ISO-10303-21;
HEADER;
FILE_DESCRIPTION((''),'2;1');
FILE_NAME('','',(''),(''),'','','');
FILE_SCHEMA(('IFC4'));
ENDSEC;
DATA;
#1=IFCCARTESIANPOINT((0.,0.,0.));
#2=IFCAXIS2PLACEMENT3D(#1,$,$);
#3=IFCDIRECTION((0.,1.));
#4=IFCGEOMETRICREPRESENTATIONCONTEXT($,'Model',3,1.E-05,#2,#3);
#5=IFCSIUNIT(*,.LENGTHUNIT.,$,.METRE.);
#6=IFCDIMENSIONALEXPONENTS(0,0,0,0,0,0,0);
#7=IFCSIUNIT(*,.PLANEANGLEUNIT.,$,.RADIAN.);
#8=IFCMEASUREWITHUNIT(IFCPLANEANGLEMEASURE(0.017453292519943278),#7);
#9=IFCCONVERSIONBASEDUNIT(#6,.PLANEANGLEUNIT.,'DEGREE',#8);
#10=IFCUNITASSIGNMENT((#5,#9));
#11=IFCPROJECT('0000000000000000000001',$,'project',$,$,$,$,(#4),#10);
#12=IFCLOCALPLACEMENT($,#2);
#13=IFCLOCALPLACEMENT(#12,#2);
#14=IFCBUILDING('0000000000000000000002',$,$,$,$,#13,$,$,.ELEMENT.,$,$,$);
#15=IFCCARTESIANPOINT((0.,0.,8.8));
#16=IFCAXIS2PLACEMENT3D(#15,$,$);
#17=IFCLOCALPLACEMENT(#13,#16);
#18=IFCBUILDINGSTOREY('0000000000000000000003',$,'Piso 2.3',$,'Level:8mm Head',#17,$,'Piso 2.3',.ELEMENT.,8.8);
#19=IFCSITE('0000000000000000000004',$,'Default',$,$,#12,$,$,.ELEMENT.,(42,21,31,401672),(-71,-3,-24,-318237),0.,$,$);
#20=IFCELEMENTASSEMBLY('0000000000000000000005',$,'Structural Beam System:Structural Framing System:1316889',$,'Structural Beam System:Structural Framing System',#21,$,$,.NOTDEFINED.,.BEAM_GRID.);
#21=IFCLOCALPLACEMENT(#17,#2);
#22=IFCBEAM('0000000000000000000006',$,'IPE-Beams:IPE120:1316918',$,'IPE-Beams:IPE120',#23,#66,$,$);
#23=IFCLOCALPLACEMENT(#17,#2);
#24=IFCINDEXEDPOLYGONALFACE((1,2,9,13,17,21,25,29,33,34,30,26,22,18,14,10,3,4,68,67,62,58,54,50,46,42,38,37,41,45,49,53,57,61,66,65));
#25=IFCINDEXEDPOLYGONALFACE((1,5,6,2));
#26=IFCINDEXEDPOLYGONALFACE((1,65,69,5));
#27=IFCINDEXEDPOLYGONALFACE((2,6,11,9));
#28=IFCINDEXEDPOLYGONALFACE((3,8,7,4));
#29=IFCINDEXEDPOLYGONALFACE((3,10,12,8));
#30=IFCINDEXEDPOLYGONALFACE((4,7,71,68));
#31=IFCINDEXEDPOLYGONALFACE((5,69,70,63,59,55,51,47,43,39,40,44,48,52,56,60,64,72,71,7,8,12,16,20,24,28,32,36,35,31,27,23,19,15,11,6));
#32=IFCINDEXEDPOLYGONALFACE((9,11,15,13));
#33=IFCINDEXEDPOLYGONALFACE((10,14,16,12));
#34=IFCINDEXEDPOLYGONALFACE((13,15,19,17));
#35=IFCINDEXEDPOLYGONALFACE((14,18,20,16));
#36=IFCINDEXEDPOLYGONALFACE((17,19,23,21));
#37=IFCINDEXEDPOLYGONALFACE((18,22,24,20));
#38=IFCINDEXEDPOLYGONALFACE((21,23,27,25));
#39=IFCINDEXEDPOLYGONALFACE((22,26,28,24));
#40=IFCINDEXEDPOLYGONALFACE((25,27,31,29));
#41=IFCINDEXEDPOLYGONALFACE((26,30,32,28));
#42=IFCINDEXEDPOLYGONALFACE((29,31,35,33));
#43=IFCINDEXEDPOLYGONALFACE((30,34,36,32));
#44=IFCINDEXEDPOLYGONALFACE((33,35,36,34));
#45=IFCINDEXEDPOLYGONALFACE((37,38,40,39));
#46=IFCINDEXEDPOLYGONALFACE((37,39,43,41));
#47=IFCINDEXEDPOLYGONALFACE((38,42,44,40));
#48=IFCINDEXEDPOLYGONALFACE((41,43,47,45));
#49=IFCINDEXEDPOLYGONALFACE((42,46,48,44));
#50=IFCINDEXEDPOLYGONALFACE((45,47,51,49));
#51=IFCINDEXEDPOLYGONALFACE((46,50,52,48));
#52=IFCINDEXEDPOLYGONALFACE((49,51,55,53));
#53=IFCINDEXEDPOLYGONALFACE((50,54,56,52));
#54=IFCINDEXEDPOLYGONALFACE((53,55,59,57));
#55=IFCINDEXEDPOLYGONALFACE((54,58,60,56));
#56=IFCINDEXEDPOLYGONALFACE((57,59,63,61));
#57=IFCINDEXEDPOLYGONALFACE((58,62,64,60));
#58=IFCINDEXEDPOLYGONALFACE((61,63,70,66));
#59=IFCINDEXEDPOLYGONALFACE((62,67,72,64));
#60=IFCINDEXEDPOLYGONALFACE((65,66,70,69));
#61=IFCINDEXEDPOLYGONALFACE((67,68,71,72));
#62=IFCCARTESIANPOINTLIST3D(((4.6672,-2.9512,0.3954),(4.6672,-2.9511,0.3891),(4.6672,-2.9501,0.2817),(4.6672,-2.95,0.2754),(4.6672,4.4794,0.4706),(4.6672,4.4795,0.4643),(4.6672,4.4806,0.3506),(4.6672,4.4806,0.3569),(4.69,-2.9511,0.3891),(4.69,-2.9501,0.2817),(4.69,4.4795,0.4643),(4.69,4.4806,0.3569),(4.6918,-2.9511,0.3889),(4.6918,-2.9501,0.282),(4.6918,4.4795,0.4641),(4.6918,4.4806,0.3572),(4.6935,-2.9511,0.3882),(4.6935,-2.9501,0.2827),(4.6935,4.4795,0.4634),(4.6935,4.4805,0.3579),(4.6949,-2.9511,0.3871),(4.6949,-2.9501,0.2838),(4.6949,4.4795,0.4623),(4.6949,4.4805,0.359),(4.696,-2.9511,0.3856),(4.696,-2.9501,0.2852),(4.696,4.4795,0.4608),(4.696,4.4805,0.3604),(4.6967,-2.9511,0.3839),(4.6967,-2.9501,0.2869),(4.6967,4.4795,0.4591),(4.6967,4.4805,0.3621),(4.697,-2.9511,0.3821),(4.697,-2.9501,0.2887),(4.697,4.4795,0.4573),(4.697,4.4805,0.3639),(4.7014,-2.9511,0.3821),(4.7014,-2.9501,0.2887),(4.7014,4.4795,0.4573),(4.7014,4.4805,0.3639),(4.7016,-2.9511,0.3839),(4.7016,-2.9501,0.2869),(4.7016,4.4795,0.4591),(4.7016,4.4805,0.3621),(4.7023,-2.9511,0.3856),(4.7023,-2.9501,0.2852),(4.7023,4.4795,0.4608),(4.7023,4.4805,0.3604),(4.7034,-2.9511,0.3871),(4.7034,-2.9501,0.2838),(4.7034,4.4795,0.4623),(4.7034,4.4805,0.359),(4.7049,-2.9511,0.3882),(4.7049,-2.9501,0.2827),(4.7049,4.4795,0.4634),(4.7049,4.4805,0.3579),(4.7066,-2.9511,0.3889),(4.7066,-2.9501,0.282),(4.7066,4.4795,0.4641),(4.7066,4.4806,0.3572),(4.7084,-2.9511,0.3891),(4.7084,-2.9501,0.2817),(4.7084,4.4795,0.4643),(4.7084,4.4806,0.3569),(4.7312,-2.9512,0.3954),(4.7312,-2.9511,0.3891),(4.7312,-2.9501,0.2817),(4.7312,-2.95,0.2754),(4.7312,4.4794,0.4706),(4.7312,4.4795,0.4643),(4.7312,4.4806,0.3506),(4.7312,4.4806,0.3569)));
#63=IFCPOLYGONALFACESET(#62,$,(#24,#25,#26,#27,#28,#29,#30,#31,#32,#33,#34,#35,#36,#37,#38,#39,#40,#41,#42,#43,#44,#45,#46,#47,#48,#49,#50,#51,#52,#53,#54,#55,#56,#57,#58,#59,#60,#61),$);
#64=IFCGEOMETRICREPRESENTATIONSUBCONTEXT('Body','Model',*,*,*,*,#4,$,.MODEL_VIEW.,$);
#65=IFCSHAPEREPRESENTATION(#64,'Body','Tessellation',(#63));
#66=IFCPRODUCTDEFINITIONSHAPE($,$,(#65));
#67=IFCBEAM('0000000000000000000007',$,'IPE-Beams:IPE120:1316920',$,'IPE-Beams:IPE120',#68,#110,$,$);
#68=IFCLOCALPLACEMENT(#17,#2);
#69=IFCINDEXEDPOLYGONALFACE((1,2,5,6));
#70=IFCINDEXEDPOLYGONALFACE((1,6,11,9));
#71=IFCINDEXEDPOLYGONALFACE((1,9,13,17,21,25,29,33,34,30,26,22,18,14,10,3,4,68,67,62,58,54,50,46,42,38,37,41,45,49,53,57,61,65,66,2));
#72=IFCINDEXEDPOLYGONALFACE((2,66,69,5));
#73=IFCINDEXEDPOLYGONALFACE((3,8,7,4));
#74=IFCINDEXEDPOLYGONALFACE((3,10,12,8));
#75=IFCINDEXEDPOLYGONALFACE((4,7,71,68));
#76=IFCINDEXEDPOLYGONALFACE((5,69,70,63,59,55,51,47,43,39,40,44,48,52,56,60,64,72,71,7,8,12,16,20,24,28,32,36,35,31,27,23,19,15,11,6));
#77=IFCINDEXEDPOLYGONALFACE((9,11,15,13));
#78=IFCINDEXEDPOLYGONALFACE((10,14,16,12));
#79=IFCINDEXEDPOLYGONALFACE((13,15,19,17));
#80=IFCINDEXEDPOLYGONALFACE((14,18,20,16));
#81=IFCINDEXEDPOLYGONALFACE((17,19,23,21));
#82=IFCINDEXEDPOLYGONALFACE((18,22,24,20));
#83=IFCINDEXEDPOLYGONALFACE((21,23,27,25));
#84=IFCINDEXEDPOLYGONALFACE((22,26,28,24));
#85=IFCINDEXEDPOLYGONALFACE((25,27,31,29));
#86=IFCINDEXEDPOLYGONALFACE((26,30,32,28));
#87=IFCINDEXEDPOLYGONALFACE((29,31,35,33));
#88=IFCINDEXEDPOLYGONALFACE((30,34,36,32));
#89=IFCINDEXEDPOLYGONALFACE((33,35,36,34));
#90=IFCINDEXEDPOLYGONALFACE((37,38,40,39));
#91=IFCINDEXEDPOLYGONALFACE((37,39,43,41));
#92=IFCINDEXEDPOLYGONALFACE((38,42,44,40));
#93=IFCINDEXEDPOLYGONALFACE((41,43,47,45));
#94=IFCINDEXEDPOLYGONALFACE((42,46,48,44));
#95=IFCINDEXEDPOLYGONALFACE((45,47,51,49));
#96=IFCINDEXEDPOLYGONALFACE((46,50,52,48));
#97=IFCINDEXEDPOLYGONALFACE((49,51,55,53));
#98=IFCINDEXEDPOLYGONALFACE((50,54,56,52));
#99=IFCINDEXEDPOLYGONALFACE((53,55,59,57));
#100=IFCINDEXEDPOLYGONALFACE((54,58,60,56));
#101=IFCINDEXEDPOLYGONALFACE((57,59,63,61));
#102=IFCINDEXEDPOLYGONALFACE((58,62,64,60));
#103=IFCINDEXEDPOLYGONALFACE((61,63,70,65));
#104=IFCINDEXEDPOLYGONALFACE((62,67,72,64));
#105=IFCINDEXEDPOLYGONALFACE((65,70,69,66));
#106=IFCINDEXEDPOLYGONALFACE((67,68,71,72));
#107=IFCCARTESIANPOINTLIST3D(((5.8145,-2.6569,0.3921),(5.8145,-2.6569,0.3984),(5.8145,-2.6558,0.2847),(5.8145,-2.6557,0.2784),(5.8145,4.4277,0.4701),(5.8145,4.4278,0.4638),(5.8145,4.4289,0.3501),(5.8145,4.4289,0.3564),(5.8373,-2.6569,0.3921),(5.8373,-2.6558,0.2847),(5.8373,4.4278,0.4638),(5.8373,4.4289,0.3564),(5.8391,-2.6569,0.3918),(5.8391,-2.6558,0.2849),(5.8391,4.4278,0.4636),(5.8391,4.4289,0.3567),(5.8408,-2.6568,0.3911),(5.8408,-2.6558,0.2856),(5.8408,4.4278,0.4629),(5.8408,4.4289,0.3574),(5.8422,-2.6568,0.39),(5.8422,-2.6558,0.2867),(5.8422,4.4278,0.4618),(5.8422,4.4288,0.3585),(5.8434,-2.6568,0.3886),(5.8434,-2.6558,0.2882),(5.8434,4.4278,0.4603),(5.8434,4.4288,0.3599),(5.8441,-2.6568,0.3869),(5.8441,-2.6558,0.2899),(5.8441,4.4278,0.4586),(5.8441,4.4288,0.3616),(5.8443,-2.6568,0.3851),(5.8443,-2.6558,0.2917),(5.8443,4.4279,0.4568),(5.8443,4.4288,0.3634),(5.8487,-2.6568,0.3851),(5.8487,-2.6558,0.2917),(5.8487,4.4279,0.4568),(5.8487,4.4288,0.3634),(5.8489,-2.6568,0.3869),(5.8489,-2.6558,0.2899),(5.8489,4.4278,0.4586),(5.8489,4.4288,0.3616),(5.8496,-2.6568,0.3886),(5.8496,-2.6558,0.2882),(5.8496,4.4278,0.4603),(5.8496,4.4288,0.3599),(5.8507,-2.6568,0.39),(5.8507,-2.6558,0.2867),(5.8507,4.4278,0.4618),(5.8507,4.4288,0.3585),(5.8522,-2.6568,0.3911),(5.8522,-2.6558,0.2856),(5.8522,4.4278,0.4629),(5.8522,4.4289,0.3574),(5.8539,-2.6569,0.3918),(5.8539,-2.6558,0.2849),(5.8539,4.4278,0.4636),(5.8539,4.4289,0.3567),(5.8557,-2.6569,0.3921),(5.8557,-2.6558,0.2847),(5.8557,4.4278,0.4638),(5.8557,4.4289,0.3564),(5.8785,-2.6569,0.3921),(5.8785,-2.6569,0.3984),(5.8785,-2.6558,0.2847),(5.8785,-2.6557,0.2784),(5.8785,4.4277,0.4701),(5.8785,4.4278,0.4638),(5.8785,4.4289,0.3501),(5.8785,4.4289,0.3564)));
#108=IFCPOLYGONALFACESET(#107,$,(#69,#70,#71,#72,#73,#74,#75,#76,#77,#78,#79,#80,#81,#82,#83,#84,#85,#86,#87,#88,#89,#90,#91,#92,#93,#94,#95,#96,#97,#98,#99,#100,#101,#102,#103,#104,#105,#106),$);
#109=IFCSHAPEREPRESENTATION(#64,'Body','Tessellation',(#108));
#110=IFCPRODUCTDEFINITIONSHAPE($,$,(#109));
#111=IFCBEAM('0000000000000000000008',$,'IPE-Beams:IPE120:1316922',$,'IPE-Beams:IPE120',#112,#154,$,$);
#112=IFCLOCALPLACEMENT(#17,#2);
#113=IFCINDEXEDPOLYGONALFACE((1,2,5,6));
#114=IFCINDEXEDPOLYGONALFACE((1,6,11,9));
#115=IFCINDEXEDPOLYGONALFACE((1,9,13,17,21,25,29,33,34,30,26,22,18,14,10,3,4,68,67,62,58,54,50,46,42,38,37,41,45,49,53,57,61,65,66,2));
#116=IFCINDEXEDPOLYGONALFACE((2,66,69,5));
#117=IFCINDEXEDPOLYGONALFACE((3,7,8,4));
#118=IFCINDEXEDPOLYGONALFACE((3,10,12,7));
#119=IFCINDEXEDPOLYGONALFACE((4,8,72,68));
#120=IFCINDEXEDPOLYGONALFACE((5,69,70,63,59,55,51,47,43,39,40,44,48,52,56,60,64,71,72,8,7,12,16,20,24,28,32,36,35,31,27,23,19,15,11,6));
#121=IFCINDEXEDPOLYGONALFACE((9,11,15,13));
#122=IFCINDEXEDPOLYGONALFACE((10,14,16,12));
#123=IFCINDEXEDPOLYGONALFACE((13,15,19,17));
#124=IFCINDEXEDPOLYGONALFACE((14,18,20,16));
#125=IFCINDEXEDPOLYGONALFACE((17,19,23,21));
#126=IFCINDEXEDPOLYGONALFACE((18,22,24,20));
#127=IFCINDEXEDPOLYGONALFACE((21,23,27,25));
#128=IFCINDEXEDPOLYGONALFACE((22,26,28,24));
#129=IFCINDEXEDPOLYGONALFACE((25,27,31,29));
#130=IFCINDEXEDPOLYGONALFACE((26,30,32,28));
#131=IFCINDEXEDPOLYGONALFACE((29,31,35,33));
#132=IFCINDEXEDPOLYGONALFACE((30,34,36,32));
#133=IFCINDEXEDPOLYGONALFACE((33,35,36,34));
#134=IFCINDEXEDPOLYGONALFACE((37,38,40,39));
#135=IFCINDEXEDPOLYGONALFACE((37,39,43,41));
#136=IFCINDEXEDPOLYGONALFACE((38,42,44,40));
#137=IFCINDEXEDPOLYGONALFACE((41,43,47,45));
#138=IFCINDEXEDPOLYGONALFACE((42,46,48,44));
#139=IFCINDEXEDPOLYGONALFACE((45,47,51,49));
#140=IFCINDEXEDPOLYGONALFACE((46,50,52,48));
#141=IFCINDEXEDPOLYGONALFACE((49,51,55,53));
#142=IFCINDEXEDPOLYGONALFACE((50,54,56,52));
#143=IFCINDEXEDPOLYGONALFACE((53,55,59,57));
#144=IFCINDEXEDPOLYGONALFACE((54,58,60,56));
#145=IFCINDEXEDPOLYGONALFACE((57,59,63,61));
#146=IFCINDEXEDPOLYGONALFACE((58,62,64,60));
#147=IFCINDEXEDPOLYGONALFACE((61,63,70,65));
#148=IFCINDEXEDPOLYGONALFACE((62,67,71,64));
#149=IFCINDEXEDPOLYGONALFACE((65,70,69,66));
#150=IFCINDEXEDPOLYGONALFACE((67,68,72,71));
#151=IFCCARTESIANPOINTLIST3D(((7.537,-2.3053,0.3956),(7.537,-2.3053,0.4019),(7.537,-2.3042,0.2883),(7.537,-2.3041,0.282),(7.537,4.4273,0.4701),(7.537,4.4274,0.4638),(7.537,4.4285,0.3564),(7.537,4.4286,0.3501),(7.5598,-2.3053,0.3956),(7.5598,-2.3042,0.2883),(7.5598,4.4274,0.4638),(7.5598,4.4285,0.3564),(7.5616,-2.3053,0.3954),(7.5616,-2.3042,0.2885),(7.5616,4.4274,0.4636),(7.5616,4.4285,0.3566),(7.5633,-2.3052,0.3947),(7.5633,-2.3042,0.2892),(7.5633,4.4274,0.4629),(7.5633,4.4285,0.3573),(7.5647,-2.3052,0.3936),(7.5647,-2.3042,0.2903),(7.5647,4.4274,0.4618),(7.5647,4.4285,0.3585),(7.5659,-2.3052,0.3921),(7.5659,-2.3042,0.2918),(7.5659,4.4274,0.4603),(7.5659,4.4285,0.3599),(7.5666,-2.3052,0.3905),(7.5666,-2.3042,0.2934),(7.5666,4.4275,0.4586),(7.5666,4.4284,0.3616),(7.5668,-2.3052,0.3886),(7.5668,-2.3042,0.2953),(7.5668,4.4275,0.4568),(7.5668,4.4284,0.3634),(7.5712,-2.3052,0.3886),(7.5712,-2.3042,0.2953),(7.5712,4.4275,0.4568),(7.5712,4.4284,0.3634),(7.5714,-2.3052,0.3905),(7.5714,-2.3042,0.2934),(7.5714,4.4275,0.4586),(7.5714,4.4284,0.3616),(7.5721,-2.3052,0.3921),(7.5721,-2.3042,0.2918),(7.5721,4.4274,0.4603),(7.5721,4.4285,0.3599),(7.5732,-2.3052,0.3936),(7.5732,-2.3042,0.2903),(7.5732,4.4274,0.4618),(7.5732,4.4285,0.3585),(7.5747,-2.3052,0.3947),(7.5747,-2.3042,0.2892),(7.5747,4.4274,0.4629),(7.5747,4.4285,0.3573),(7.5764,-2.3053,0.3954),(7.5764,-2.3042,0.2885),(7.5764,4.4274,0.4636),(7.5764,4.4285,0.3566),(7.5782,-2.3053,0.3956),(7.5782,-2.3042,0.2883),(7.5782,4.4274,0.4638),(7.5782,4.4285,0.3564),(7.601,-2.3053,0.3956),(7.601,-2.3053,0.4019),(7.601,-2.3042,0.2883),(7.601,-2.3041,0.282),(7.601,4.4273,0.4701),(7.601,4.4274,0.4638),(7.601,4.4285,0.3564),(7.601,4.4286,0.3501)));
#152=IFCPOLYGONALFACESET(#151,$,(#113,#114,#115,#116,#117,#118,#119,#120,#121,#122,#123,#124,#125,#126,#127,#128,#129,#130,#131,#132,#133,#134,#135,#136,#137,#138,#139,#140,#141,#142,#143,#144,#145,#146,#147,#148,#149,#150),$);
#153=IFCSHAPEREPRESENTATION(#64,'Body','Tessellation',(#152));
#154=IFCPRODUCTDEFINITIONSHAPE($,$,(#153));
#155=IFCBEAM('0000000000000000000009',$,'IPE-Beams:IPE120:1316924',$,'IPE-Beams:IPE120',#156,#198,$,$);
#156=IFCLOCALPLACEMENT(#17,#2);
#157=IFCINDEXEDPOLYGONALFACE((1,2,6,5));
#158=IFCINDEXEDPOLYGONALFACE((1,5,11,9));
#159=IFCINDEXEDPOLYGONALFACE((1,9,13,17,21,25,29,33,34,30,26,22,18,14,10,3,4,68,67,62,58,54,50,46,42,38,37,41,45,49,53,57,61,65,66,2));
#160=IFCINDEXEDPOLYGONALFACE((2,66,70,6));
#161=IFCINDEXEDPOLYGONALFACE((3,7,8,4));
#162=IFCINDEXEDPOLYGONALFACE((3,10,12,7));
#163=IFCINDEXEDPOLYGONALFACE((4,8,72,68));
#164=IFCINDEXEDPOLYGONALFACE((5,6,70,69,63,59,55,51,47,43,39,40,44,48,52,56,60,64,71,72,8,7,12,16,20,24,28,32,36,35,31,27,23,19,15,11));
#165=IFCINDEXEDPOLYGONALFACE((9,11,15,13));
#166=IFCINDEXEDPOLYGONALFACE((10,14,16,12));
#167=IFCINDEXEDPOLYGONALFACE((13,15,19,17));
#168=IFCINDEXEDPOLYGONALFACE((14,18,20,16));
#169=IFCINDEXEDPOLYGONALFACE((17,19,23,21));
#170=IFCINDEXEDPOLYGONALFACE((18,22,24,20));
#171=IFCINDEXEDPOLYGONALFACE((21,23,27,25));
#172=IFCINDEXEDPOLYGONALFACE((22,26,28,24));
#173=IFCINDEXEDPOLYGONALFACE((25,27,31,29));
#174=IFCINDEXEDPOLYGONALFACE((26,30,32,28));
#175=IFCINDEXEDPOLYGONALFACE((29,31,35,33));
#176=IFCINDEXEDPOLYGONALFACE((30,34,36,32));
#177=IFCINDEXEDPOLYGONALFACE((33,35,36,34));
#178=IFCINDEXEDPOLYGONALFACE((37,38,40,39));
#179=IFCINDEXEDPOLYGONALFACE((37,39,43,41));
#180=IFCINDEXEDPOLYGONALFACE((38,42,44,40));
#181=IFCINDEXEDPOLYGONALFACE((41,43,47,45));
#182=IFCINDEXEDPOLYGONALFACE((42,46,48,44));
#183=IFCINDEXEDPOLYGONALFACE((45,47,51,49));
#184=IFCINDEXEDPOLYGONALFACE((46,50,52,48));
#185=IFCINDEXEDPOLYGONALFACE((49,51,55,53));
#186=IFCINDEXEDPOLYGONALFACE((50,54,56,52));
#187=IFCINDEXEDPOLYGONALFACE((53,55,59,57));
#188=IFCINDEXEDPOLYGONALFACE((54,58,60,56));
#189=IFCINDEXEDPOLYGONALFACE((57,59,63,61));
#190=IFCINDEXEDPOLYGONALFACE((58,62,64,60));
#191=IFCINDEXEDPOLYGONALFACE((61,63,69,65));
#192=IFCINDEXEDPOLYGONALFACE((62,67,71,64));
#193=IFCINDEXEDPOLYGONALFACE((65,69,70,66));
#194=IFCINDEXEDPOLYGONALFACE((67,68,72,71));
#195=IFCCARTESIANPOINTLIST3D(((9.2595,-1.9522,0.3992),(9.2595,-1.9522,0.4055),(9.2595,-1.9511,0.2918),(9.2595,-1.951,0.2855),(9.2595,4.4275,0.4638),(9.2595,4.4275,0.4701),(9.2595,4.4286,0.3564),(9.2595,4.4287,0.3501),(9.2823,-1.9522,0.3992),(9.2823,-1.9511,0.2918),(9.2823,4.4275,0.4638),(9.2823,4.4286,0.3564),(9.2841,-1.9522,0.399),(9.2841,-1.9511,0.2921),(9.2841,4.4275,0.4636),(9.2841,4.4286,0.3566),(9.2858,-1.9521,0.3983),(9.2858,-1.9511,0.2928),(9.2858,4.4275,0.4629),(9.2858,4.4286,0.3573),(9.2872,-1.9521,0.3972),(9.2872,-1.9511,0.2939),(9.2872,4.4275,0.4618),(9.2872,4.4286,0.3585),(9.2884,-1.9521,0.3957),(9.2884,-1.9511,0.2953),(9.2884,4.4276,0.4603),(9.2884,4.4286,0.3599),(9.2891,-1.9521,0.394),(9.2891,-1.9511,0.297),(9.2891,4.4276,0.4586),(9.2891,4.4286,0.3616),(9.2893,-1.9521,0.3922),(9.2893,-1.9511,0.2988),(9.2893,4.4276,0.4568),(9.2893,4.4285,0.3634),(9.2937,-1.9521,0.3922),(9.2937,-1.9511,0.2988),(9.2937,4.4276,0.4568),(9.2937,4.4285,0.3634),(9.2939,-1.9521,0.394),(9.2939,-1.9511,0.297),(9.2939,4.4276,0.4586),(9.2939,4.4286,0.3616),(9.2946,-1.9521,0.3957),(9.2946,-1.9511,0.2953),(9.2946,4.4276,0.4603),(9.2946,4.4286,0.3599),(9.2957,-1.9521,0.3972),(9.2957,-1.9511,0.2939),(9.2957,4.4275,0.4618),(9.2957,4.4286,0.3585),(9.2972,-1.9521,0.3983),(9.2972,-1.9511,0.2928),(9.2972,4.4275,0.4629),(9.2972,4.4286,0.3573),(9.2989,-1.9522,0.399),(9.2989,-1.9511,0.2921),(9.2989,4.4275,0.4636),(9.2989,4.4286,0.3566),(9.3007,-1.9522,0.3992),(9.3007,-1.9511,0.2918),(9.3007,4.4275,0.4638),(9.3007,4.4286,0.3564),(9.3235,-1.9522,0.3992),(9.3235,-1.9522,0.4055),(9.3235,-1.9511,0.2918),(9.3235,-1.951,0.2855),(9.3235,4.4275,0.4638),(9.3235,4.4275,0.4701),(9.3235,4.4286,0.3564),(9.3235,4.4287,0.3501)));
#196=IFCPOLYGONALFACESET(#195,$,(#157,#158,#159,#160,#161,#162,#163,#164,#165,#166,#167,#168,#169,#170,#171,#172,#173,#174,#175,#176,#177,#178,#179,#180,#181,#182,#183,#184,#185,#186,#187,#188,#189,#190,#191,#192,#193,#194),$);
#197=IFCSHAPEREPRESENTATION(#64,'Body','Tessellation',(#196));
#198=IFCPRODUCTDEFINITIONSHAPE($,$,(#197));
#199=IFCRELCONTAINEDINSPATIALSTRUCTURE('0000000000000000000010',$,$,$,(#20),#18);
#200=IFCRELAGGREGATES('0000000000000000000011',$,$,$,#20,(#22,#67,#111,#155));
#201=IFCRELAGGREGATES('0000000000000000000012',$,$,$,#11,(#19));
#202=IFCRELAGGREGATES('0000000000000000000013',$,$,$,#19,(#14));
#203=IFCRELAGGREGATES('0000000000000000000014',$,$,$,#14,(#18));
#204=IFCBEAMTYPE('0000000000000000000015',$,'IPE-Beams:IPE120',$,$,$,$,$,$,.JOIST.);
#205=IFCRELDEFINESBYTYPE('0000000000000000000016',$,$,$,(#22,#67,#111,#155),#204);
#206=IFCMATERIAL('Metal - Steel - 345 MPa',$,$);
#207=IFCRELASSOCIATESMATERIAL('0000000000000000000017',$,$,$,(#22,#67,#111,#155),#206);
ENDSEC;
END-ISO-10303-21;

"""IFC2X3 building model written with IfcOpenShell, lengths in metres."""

from ifc_helpers import new_model, entity, si_unit, converted_unit, direction, frame, frame_2d, origin, place, context, subcontext, project, spatial, i_section, extrude, material, type_object, element, aggregate, save


model = new_model("IFC2X3")

# Units and contexts
model_context = context("Model", 3, precision=1e-05, world=origin(), true_north=direction((0.0, 1.0)))
body_context = subcontext(model_context, "Body", "Model", "MODEL_VIEW")
ifc_project = project(units=[si_unit("LENGTHUNIT", "METRE"), converted_unit("PLANEANGLEUNIT", "DEGREE", entity("IfcPlaneAngleMeasure", 0.017453292519943278), si_unit("PLANEANGLEUNIT", "RADIAN"), dimensions=[0, 0, 0, 0, 0, 0, 0])], contexts=[model_context])

# Site, building, storey
site_placement = place(None, origin())
site = spatial("IfcSite", under=ifc_project, at=site_placement, Name="Default", CompositionType="ELEMENT", RefLatitude=(42, 21, 31, 401672), RefLongitude=(-71, -3, -24, -318237), RefElevation=0.0)
building_placement = place(site_placement, origin())
building = spatial("IfcBuilding", under=site, at=building_placement, CompositionType="ELEMENT")
storey_placement = place(building_placement, frame((0.0, 0.0, 8.8)))
storey = spatial("IfcBuildingStorey", under=building, at=storey_placement, Name="Piso 2.3", ObjectType="Level:8mm Head", LongName="Piso 2.3", CompositionType="ELEMENT", Elevation=8.8)

# Shared definitions
ifc_material_1 = material(Name="Metal - Steel - 345 MPa")

# Element assembly, beams
assembly_placement = place(storey_placement, origin())
assembly = element("IfcElementAssembly", 1, at=assembly_placement, inside=storey, Name="Structural Beam System:Structural Framing System:1316889", ObjectType="Structural Beam System:Structural Framing System", AssemblyPlace="NOTDEFINED", PredefinedType="BEAM_GRID")
beam_type_1 = type_object("IfcBeamType", Name="IPE-Beams:IPE120", PredefinedType="JOIST")
beam_1_placement = place(assembly_placement, frame((4.6992, -2.9512, 0.3954), z_axis=(0.0, -0.010123, 0.999949), x_axis=(0.0, 0.999949, 0.010123)))
beam_1 = element("IfcBeam", 2, at=beam_1_placement, type_object=beam_type_1, material=ifc_material_1, Name="IPE-Beams:IPE120:1316918", ObjectType="IPE-Beams:IPE120", context=body_context, shape_type="SweptSolid", body=[
    extrude(i_section(OverallWidth=0.064, OverallDepth=0.12, WebThickness=0.0044, FlangeThickness=0.0063, FilletRadius=0.007, at=frame_2d((0.0, 0.0), x_axis=(0.0, 1.0))), frame((0.0, 0.0, -0.06), z_axis=(1.0, 0.0, 0.0), x_axis=(0.0, 0.0, -1.0)), (0.0, 0.0, 1.0), 7.431),
])
beam_2_placement = place(assembly_placement, frame((5.8465, -2.7166, 0.3978), z_axis=(0.0, -0.010123, 0.999949), x_axis=(0.0, 0.999949, 0.010123)))
beam_2 = element("IfcBeam", 3, at=beam_2_placement, type_object=beam_type_1, material=ifc_material_1, Name="IPE-Beams:IPE120:1316920", ObjectType="IPE-Beams:IPE120", context=body_context, shape_type="SweptSolid", body=[
    extrude(i_section(OverallWidth=0.064, OverallDepth=0.12, WebThickness=0.0044, FlangeThickness=0.0063, FilletRadius=0.007, at=frame_2d((0.0, 0.0), x_axis=(0.0, 1.0))), frame((0.0597, 0.0, -0.06), z_axis=(1.0, 0.0, 0.0), x_axis=(0.0, 0.0, -1.0)), (0.0, 0.0, 1.0), 7.085),
])
beam_3_placement = place(assembly_placement, frame((7.569, -2.3644, 0.4013), z_axis=(0.0, -0.010123, 0.999949), x_axis=(0.0, 0.999949, 0.010123)))
beam_3 = element("IfcBeam", 4, at=beam_3_placement, type_object=beam_type_1, material=ifc_material_1, Name="IPE-Beams:IPE120:1316922", ObjectType="IPE-Beams:IPE120", context=body_context, shape_type="SweptSolid", body=[
    extrude(i_section(OverallWidth=0.064, OverallDepth=0.12, WebThickness=0.0044, FlangeThickness=0.0063, FilletRadius=0.007, at=frame_2d((0.0, 0.0), x_axis=(0.0, 1.0))), frame((0.0591, 0.0, -0.06), z_axis=(1.0, 0.0, 0.0), x_axis=(0.0, 0.0, -1.0)), (0.0, 0.0, 1.0), 6.733),
])
beam_4_placement = place(assembly_placement, frame((9.2915, -2.0122, 0.4049), z_axis=(0.0, -0.010123, 0.999949), x_axis=(0.0, 0.999949, 0.010123)))
beam_4 = element("IfcBeam", 5, at=beam_4_placement, type_object=beam_type_1, material=ifc_material_1, Name="IPE-Beams:IPE120:1316924", ObjectType="IPE-Beams:IPE120", context=body_context, shape_type="SweptSolid", body=[
    extrude(i_section(OverallWidth=0.064, OverallDepth=0.12, WebThickness=0.0044, FlangeThickness=0.0063, FilletRadius=0.007, at=frame_2d((0.0, 0.0), x_axis=(0.0, 1.0))), frame((0.06, 0.0, -0.06), z_axis=(1.0, 0.0, 0.0), x_axis=(0.0, 0.0, -1.0)), (0.0, 0.0, 1.0), 6.38),
])
aggregate(assembly, [beam_1, beam_2, beam_3, beam_4])

save(model, "model.ifc")
